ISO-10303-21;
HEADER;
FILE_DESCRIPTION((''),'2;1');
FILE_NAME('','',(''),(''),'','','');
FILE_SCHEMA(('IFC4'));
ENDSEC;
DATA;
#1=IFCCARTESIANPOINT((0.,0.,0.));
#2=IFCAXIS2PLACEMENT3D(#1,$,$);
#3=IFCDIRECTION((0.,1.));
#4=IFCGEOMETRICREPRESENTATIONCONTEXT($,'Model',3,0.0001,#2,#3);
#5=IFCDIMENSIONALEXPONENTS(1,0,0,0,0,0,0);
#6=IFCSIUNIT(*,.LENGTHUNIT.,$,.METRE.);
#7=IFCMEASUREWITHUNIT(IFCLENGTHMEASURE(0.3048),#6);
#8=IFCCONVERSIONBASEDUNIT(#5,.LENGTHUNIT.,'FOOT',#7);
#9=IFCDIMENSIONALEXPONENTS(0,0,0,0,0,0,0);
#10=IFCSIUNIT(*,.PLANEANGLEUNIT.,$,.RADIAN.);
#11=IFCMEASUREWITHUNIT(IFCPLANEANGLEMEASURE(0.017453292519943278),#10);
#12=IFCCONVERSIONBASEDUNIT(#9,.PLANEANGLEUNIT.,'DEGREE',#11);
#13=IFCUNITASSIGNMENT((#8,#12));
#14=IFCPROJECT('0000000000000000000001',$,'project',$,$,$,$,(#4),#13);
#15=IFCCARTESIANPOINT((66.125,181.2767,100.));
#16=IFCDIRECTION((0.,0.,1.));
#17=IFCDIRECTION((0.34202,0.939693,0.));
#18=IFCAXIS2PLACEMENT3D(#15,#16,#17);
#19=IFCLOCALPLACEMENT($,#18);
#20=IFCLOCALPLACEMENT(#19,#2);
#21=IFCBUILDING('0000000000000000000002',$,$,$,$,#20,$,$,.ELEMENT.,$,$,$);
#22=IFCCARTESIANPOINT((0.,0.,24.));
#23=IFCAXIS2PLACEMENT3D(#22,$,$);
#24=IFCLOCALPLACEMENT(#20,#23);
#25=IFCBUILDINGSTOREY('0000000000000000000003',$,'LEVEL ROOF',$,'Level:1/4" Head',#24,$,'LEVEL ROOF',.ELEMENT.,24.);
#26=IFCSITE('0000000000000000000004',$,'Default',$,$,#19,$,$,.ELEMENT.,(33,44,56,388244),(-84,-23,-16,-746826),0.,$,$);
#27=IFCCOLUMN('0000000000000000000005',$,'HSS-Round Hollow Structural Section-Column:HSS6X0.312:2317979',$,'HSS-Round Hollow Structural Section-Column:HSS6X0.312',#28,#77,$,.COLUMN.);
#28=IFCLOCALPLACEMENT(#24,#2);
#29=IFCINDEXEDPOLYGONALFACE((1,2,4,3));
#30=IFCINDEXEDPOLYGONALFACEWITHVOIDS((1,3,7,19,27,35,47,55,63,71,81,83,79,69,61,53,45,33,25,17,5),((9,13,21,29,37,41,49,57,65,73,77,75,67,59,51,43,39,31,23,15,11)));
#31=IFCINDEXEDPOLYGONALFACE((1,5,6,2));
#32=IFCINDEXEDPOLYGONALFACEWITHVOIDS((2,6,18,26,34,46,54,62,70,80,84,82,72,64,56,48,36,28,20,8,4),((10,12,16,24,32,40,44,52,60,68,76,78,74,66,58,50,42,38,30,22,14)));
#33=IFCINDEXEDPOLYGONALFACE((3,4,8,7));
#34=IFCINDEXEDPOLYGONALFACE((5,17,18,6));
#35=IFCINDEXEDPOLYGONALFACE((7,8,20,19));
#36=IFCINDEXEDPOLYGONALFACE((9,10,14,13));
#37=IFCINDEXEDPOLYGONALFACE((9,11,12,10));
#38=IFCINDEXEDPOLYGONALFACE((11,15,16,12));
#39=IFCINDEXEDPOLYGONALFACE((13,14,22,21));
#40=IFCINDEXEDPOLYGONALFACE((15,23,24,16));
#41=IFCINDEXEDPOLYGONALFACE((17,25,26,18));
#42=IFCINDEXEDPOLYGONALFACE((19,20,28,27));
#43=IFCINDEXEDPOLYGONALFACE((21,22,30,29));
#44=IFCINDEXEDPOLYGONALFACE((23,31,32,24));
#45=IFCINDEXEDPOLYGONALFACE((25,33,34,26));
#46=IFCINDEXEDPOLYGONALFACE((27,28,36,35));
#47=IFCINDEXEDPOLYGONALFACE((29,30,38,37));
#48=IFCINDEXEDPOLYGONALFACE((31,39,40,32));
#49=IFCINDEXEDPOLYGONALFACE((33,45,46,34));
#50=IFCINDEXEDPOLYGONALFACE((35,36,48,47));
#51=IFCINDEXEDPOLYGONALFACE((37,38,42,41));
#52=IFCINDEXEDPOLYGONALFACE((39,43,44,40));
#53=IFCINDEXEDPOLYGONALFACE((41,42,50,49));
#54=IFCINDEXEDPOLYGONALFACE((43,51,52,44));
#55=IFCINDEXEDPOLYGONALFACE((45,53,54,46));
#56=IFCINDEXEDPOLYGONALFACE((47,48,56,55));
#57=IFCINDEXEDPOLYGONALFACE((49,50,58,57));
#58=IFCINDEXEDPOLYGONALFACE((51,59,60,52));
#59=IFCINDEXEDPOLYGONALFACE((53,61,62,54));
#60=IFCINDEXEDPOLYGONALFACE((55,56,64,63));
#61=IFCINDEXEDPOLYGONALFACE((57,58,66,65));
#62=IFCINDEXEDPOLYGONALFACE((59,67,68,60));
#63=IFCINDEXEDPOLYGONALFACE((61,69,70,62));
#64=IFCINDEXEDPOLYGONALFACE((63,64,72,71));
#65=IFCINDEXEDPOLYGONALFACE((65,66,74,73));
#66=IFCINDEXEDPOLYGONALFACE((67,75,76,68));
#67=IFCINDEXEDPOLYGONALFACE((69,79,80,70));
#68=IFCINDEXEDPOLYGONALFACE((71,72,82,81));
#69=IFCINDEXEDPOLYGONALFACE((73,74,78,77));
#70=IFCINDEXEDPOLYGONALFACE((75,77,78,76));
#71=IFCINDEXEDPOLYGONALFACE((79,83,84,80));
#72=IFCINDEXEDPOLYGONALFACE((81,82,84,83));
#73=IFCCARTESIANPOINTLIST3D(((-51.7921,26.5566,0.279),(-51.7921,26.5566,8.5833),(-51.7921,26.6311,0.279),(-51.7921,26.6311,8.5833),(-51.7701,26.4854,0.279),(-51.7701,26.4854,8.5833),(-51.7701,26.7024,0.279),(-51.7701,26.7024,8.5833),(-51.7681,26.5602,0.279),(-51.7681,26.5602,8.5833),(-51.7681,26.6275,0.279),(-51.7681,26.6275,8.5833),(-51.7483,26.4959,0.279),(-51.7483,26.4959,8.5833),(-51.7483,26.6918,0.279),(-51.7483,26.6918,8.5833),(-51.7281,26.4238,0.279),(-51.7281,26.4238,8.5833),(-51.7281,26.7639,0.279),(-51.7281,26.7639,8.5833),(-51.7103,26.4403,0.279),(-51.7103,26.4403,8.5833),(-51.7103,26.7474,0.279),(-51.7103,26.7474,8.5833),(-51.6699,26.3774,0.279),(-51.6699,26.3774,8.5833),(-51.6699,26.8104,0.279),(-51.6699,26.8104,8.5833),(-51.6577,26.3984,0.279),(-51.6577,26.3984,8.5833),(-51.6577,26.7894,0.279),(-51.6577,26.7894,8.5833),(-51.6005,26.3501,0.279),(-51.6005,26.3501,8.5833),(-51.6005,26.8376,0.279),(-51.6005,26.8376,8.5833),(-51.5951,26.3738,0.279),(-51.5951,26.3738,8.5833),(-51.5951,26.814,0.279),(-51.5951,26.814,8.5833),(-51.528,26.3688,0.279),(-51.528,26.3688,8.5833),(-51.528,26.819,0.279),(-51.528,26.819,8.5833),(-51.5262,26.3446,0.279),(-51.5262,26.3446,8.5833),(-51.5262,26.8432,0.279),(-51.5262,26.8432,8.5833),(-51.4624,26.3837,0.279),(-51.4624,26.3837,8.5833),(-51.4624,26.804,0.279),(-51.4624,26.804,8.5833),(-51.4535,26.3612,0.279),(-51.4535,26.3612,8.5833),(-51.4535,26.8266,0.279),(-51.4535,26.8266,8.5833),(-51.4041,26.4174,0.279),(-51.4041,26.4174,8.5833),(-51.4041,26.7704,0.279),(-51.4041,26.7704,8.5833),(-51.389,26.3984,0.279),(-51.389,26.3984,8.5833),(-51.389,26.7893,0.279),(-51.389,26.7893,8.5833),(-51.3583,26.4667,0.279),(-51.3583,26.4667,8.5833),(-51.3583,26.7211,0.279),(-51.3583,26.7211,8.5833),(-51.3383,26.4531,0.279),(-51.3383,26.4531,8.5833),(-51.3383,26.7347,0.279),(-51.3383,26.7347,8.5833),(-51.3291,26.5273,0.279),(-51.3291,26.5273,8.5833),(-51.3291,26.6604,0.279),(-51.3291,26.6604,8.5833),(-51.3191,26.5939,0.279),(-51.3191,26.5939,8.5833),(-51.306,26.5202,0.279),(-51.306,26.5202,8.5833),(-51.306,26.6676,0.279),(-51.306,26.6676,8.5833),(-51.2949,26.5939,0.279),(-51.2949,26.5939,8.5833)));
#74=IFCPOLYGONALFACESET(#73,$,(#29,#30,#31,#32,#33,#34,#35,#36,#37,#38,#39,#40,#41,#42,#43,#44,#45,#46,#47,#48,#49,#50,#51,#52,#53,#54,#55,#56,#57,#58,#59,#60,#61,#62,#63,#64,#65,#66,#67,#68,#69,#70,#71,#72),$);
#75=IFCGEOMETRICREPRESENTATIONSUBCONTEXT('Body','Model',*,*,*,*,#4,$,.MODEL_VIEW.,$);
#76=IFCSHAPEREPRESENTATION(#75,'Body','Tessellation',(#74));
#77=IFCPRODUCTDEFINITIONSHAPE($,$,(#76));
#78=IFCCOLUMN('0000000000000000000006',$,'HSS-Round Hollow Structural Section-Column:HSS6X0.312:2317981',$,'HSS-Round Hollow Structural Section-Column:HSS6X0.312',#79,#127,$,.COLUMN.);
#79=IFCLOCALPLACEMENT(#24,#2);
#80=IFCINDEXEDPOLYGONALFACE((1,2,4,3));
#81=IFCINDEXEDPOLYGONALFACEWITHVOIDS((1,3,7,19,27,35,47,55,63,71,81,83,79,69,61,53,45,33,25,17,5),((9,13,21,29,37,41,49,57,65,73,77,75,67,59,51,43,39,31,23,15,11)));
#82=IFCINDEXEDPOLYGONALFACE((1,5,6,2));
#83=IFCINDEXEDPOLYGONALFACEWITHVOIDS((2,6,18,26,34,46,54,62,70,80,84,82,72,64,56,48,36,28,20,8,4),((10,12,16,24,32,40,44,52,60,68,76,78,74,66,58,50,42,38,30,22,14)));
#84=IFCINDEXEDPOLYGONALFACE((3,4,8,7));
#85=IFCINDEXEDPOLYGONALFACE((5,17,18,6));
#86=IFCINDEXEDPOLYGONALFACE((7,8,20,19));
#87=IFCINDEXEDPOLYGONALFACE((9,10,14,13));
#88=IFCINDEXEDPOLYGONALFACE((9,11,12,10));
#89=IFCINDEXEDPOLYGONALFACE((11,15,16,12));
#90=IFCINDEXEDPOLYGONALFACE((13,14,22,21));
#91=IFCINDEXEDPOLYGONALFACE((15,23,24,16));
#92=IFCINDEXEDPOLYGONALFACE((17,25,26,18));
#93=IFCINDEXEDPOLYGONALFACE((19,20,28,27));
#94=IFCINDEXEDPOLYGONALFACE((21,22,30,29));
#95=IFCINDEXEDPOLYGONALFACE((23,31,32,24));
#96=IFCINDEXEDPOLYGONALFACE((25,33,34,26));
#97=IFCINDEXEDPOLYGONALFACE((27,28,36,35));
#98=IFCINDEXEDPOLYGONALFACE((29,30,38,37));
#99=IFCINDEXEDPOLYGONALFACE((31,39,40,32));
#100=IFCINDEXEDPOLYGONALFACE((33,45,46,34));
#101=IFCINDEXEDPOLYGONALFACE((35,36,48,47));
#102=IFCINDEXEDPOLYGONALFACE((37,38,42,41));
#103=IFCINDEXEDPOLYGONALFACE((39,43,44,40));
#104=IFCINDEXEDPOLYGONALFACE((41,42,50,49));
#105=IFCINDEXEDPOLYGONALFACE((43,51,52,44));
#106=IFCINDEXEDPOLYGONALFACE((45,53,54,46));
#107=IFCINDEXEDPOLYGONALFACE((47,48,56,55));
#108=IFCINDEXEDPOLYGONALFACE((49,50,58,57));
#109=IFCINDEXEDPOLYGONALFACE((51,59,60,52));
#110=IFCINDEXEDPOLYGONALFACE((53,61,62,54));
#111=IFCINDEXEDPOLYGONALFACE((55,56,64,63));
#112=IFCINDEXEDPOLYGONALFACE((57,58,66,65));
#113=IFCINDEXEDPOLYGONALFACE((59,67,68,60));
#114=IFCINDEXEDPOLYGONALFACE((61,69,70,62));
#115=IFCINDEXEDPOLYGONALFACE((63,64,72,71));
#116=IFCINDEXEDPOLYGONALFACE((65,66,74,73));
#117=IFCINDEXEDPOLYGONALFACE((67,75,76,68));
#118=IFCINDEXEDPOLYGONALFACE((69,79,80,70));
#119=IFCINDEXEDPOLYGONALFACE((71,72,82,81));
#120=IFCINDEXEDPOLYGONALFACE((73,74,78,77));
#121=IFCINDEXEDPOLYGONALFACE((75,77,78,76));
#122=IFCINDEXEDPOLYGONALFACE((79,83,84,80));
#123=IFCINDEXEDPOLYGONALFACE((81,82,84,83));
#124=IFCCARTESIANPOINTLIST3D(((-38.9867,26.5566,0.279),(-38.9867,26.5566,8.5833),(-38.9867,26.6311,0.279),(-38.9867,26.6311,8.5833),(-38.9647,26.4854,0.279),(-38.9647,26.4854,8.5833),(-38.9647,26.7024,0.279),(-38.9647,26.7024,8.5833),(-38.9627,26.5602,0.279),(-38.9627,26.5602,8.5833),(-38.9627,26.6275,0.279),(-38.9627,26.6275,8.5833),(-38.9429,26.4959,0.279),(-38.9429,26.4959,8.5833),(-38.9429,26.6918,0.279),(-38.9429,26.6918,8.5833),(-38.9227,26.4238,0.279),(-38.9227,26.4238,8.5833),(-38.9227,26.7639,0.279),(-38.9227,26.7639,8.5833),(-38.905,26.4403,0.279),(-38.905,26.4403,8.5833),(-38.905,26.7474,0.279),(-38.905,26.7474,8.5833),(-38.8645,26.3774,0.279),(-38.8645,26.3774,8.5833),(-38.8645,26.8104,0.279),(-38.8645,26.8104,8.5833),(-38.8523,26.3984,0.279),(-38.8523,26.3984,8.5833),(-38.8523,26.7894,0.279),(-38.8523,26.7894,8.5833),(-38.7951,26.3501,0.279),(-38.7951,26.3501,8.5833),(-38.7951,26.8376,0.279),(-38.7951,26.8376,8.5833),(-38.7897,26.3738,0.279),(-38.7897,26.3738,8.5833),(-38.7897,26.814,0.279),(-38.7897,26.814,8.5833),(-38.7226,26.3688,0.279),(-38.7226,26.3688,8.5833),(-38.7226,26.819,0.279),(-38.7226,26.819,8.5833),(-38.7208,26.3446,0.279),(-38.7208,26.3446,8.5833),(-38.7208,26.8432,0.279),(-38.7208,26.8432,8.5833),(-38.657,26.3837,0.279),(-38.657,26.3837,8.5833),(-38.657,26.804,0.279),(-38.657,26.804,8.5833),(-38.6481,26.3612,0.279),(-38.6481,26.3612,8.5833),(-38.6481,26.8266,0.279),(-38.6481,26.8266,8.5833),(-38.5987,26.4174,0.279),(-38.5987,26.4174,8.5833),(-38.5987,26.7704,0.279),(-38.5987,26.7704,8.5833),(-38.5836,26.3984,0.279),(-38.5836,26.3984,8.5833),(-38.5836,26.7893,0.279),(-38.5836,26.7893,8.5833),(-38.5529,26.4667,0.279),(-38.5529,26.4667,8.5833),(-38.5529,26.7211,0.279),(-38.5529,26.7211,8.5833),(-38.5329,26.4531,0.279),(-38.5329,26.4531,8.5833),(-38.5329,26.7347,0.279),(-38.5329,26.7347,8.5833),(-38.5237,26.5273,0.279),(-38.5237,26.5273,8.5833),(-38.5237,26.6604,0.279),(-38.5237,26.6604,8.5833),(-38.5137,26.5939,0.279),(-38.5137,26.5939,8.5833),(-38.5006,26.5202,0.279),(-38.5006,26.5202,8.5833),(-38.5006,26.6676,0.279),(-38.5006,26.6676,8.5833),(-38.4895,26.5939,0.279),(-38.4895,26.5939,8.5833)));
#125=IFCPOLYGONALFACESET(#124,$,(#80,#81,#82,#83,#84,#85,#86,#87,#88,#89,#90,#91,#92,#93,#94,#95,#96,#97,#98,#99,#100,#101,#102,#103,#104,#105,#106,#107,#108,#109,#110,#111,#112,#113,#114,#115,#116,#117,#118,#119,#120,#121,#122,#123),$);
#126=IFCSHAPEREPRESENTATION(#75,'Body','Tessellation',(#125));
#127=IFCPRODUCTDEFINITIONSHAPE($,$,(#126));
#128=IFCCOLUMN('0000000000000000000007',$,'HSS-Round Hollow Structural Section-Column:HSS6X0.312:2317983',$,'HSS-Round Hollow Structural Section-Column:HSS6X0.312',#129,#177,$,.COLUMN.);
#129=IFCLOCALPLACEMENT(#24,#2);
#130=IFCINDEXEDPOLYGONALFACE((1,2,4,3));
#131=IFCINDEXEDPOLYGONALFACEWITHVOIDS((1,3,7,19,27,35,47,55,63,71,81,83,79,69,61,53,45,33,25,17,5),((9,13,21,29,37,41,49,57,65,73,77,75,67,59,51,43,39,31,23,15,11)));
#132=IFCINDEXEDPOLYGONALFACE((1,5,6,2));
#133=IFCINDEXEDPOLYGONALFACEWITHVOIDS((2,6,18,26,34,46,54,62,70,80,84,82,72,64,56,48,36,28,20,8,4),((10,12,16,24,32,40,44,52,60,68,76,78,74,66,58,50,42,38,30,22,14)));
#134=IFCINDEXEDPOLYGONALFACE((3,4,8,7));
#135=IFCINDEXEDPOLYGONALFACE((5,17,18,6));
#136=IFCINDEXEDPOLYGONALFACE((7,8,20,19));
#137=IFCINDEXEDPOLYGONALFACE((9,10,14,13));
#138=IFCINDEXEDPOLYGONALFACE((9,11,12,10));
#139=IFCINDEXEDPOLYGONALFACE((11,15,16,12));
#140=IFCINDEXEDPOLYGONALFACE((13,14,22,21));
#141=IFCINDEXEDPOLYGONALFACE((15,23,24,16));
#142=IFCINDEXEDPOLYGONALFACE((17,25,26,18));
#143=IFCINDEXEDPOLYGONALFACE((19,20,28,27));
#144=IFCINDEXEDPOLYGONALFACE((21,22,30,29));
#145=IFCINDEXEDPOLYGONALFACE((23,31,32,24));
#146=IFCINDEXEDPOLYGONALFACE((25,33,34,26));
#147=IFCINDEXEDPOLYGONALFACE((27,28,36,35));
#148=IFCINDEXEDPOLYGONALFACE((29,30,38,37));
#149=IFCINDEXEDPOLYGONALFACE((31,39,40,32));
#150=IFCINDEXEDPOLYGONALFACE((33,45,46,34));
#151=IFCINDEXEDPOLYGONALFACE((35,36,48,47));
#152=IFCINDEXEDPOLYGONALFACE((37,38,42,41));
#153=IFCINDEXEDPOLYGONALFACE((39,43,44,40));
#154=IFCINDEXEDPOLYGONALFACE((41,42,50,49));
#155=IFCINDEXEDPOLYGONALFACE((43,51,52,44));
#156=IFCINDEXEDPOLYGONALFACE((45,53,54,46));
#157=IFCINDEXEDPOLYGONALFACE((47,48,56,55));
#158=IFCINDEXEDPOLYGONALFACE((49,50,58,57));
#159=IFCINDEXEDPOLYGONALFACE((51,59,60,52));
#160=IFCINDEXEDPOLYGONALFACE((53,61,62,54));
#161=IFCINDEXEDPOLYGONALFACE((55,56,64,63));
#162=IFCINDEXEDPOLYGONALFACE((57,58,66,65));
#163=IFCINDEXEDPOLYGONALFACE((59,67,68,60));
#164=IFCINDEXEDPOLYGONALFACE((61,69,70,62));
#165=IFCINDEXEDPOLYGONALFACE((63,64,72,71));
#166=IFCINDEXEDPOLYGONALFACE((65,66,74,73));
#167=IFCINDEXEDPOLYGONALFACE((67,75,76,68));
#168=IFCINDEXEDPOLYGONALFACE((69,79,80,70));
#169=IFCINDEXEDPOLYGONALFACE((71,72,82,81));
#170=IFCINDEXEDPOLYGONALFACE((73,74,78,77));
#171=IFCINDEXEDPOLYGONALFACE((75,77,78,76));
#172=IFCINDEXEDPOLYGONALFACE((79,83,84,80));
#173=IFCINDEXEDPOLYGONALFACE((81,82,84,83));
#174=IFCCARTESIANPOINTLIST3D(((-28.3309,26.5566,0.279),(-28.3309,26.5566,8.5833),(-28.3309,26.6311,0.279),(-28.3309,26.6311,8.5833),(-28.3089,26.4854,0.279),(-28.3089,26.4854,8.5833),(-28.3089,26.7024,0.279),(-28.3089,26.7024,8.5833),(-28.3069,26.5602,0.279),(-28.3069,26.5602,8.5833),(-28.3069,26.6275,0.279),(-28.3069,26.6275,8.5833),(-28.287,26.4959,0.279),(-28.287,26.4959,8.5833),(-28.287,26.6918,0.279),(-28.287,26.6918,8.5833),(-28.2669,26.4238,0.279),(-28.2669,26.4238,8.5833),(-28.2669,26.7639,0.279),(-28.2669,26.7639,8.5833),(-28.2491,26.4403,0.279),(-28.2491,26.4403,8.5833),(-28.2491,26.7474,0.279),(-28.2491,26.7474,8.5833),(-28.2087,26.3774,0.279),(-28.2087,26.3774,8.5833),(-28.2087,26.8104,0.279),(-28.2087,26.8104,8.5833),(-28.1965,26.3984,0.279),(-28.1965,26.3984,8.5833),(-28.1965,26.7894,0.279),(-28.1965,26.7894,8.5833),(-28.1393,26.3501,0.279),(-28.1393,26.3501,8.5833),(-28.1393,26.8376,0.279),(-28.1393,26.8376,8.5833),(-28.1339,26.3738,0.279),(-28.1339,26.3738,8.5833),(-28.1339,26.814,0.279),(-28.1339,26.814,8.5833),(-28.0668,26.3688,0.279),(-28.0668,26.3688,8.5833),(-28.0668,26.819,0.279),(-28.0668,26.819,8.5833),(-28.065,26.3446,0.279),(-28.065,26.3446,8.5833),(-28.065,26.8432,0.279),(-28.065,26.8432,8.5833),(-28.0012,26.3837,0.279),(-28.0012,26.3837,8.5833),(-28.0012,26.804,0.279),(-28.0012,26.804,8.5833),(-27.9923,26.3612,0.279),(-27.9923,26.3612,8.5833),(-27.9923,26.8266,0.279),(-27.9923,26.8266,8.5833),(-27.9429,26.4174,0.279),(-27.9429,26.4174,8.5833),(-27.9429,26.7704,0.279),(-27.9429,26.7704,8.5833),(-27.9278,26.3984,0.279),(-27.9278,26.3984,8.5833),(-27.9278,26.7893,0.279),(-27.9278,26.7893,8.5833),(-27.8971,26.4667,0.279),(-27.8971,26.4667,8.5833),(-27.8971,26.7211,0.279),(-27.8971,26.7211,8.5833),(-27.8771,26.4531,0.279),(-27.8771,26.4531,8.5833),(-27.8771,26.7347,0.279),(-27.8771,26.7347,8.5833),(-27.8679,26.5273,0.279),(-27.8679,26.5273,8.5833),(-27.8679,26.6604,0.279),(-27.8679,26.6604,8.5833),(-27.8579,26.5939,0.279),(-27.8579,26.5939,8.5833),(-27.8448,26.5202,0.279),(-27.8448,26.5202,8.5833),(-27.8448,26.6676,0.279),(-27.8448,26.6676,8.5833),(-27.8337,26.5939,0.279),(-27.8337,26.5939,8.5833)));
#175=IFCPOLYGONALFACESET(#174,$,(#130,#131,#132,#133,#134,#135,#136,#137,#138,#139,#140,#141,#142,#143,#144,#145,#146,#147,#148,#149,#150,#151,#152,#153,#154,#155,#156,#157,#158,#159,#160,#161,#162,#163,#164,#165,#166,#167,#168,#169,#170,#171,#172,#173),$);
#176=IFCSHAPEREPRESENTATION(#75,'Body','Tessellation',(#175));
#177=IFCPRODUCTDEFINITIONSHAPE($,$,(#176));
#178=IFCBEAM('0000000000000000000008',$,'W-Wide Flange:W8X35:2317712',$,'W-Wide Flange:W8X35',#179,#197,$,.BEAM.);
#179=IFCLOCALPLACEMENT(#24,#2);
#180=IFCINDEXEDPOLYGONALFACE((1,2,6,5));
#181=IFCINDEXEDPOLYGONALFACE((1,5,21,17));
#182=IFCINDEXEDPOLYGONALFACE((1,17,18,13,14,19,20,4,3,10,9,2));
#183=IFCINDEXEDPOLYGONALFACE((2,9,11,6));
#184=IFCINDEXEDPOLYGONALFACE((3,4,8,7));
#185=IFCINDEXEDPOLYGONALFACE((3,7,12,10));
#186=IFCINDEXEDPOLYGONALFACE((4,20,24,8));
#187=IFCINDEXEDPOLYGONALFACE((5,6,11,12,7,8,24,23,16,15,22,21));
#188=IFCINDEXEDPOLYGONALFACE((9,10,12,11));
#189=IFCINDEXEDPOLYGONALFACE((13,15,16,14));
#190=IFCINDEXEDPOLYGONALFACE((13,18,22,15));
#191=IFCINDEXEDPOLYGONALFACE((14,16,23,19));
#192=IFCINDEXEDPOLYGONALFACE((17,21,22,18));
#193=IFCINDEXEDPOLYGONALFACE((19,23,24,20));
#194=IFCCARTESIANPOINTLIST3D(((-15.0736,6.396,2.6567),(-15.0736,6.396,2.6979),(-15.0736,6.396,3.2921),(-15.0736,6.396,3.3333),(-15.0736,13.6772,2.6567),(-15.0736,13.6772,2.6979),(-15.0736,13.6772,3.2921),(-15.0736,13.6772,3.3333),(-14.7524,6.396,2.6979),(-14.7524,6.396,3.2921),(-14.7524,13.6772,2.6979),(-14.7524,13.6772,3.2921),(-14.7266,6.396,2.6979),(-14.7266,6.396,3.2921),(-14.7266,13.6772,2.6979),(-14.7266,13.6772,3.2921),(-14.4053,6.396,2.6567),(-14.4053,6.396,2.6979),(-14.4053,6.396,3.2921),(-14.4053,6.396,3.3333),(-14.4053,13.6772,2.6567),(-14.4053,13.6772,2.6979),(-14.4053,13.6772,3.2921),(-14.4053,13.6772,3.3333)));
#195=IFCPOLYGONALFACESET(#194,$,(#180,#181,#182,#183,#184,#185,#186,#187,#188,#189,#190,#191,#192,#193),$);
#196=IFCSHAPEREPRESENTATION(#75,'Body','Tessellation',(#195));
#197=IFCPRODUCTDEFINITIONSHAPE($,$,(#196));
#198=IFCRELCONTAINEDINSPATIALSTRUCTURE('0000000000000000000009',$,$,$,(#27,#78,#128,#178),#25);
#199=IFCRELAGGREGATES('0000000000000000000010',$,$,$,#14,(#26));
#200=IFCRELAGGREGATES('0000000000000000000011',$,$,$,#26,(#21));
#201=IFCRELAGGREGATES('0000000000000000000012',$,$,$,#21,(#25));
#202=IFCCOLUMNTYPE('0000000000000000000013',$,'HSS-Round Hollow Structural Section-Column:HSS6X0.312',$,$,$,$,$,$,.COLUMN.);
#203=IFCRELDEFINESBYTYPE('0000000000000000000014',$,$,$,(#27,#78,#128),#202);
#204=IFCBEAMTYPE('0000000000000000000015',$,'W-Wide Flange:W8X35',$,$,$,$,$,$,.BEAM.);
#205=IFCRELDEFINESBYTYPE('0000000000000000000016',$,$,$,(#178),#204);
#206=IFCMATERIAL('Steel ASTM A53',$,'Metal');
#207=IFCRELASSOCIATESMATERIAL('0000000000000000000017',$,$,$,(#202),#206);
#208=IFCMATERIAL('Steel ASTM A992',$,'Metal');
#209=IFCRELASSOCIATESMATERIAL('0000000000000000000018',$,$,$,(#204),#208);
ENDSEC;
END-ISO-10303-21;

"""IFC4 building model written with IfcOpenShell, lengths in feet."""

from ifc_helpers import new_model, entity, si_unit, converted_unit, direction, frame, frame_2d, origin, place, context, subcontext, project, spatial, hollow_circle, i_section, extrude, source, transform, mapped, material, material_profile, profile_set, type_object, type_shapes, element, save


model = new_model("IFC4")

# Units and contexts
model_context = context("Model", 3, precision=0.0001, world=origin(), true_north=direction((0.0, 1.0)))
body_context = subcontext(model_context, "Body", "Model", "MODEL_VIEW")
ifc_project = project(units=[converted_unit("LENGTHUNIT", "FOOT", entity("IfcLengthMeasure", 0.3048), si_unit("LENGTHUNIT", "METRE"), dimensions=[1, 0, 0, 0, 0, 0, 0]), converted_unit("PLANEANGLEUNIT", "DEGREE", entity("IfcPlaneAngleMeasure", 0.017453292519943278), si_unit("PLANEANGLEUNIT", "RADIAN"), dimensions=[0, 0, 0, 0, 0, 0, 0])], contexts=[model_context])

# Site, building, storey
site_placement = place(None, frame((66.125, 181.2767, 100.0), z_axis=(0.0, 0.0, 1.0), x_axis=(0.34202, 0.939693, 0.0)))
site = spatial("IfcSite", under=ifc_project, at=site_placement, Name="Default", CompositionType="ELEMENT", RefLatitude=(33, 44, 56, 388244), RefLongitude=(-84, -23, -16, -746826), RefElevation=0.0)
building_placement = place(site_placement, origin())
building = spatial("IfcBuilding", under=site, at=building_placement, CompositionType="ELEMENT")
storey_placement = place(building_placement, frame((0.0, 0.0, 24.0)))
storey = spatial("IfcBuildingStorey", under=building, at=storey_placement, Name="LEVEL ROOF", ObjectType="Level:1/4\" Head", LongName="LEVEL ROOF", CompositionType="ELEMENT", Elevation=24.0)

# Columns
ifc_material_1 = material(Name="Steel ASTM A53", Category="Metal")
ifc_material_profile_1 = material_profile(ifc_material_1, hollow_circle(Radius=0.25, WallThickness=0.0242, at=frame_2d((0.0, 0.0), x_axis=(1.0, 0.0))), Name="HSS6X0.312")
ifc_profile_set_1 = profile_set([ifc_material_profile_1], Name="HSS6X0.312")
column_type_1 = type_object("IfcColumnType", Name="HSS-Round Hollow Structural Section-Column:HSS6X0.312", PredefinedType="COLUMN", material=ifc_profile_set_1)
shared_shape_1 = source(origin(), body_context, "Body", "SweptSolid", [
    extrude(hollow_circle(Radius=0.25, WallThickness=0.0242, at=frame_2d((0.0, 0.0), x_axis=(1.0, 0.0))), frame((0.0, 0.0, 24.279)), (0.0, 0.0, 1.0), 8.3044),
])
type_shapes(column_type_1, [shared_shape_1])
for number, where, name in (
    (1, (-51.5449, 26.5939, -24.0), "HSS-Round Hollow Structural Section-Column:HSS6X0.312:2317979"),
    (2, (-38.7395, 26.5939, -24.0), "HSS-Round Hollow Structural Section-Column:HSS6X0.312:2317981"),
    (3, (-28.0837, 26.5939, -24.0), "HSS-Round Hollow Structural Section-Column:HSS6X0.312:2317983"),
):
    element("IfcColumn", number, at=place(storey_placement, frame(where)), inside=storey, type_object=column_type_1, Name=name, ObjectType="HSS-Round Hollow Structural Section-Column:HSS6X0.312", PredefinedType="COLUMN", context=body_context, shape_type="MappedRepresentation", body=[
        mapped(shared_shape_1, transform((0.0, 0.0, 0.0), scale=1.0)),
    ])

# Beam
ifc_material_2 = material(Name="Steel ASTM A992", Category="Metal")
ifc_material_profile_2 = material_profile(ifc_material_2, i_section(OverallWidth=0.6683, OverallDepth=0.6767, WebThickness=0.0258, FlangeThickness=0.0413, at=frame_2d((0.0, 0.0), x_axis=(0.0, 1.0))), Name="W8X35")
ifc_profile_set_2 = profile_set([ifc_material_profile_2], Name="W8X35")
beam_type = type_object("IfcBeamType", Name="W-Wide Flange:W8X35", PredefinedType="BEAM", material=ifc_profile_set_2)
shared_shape_2 = source(origin(), body_context, "Body", "SweptSolid", [
    extrude(i_section(OverallWidth=0.6683, OverallDepth=0.6767, WebThickness=0.0258, FlangeThickness=0.0413, at=frame_2d((0.0, 0.0), x_axis=(0.0, 1.0))), frame((-3.6406, 0.0, 0.0), z_axis=(1.0, 0.0, 0.0), x_axis=(0.0, 0.0, -1.0)), (0.0, 0.0, 1.0), 7.2812),
])
type_shapes(beam_type, [shared_shape_2])
beam_placement = place(storey_placement, frame((-14.7395, 10.0366, 2.995), z_axis=(0.0, 0.0, 1.0), x_axis=(0.0, -1.0, 0.0)))
element("IfcBeam", 4, at=beam_placement, inside=storey, type_object=beam_type, Name="W-Wide Flange:W8X35:2317712", ObjectType="W-Wide Flange:W8X35", PredefinedType="BEAM", context=body_context, shape_type="MappedRepresentation", body=[
    mapped(shared_shape_2, transform((0.0, 0.0, 0.0), scale=1.0)),
])

save(model, "model.ifc")
